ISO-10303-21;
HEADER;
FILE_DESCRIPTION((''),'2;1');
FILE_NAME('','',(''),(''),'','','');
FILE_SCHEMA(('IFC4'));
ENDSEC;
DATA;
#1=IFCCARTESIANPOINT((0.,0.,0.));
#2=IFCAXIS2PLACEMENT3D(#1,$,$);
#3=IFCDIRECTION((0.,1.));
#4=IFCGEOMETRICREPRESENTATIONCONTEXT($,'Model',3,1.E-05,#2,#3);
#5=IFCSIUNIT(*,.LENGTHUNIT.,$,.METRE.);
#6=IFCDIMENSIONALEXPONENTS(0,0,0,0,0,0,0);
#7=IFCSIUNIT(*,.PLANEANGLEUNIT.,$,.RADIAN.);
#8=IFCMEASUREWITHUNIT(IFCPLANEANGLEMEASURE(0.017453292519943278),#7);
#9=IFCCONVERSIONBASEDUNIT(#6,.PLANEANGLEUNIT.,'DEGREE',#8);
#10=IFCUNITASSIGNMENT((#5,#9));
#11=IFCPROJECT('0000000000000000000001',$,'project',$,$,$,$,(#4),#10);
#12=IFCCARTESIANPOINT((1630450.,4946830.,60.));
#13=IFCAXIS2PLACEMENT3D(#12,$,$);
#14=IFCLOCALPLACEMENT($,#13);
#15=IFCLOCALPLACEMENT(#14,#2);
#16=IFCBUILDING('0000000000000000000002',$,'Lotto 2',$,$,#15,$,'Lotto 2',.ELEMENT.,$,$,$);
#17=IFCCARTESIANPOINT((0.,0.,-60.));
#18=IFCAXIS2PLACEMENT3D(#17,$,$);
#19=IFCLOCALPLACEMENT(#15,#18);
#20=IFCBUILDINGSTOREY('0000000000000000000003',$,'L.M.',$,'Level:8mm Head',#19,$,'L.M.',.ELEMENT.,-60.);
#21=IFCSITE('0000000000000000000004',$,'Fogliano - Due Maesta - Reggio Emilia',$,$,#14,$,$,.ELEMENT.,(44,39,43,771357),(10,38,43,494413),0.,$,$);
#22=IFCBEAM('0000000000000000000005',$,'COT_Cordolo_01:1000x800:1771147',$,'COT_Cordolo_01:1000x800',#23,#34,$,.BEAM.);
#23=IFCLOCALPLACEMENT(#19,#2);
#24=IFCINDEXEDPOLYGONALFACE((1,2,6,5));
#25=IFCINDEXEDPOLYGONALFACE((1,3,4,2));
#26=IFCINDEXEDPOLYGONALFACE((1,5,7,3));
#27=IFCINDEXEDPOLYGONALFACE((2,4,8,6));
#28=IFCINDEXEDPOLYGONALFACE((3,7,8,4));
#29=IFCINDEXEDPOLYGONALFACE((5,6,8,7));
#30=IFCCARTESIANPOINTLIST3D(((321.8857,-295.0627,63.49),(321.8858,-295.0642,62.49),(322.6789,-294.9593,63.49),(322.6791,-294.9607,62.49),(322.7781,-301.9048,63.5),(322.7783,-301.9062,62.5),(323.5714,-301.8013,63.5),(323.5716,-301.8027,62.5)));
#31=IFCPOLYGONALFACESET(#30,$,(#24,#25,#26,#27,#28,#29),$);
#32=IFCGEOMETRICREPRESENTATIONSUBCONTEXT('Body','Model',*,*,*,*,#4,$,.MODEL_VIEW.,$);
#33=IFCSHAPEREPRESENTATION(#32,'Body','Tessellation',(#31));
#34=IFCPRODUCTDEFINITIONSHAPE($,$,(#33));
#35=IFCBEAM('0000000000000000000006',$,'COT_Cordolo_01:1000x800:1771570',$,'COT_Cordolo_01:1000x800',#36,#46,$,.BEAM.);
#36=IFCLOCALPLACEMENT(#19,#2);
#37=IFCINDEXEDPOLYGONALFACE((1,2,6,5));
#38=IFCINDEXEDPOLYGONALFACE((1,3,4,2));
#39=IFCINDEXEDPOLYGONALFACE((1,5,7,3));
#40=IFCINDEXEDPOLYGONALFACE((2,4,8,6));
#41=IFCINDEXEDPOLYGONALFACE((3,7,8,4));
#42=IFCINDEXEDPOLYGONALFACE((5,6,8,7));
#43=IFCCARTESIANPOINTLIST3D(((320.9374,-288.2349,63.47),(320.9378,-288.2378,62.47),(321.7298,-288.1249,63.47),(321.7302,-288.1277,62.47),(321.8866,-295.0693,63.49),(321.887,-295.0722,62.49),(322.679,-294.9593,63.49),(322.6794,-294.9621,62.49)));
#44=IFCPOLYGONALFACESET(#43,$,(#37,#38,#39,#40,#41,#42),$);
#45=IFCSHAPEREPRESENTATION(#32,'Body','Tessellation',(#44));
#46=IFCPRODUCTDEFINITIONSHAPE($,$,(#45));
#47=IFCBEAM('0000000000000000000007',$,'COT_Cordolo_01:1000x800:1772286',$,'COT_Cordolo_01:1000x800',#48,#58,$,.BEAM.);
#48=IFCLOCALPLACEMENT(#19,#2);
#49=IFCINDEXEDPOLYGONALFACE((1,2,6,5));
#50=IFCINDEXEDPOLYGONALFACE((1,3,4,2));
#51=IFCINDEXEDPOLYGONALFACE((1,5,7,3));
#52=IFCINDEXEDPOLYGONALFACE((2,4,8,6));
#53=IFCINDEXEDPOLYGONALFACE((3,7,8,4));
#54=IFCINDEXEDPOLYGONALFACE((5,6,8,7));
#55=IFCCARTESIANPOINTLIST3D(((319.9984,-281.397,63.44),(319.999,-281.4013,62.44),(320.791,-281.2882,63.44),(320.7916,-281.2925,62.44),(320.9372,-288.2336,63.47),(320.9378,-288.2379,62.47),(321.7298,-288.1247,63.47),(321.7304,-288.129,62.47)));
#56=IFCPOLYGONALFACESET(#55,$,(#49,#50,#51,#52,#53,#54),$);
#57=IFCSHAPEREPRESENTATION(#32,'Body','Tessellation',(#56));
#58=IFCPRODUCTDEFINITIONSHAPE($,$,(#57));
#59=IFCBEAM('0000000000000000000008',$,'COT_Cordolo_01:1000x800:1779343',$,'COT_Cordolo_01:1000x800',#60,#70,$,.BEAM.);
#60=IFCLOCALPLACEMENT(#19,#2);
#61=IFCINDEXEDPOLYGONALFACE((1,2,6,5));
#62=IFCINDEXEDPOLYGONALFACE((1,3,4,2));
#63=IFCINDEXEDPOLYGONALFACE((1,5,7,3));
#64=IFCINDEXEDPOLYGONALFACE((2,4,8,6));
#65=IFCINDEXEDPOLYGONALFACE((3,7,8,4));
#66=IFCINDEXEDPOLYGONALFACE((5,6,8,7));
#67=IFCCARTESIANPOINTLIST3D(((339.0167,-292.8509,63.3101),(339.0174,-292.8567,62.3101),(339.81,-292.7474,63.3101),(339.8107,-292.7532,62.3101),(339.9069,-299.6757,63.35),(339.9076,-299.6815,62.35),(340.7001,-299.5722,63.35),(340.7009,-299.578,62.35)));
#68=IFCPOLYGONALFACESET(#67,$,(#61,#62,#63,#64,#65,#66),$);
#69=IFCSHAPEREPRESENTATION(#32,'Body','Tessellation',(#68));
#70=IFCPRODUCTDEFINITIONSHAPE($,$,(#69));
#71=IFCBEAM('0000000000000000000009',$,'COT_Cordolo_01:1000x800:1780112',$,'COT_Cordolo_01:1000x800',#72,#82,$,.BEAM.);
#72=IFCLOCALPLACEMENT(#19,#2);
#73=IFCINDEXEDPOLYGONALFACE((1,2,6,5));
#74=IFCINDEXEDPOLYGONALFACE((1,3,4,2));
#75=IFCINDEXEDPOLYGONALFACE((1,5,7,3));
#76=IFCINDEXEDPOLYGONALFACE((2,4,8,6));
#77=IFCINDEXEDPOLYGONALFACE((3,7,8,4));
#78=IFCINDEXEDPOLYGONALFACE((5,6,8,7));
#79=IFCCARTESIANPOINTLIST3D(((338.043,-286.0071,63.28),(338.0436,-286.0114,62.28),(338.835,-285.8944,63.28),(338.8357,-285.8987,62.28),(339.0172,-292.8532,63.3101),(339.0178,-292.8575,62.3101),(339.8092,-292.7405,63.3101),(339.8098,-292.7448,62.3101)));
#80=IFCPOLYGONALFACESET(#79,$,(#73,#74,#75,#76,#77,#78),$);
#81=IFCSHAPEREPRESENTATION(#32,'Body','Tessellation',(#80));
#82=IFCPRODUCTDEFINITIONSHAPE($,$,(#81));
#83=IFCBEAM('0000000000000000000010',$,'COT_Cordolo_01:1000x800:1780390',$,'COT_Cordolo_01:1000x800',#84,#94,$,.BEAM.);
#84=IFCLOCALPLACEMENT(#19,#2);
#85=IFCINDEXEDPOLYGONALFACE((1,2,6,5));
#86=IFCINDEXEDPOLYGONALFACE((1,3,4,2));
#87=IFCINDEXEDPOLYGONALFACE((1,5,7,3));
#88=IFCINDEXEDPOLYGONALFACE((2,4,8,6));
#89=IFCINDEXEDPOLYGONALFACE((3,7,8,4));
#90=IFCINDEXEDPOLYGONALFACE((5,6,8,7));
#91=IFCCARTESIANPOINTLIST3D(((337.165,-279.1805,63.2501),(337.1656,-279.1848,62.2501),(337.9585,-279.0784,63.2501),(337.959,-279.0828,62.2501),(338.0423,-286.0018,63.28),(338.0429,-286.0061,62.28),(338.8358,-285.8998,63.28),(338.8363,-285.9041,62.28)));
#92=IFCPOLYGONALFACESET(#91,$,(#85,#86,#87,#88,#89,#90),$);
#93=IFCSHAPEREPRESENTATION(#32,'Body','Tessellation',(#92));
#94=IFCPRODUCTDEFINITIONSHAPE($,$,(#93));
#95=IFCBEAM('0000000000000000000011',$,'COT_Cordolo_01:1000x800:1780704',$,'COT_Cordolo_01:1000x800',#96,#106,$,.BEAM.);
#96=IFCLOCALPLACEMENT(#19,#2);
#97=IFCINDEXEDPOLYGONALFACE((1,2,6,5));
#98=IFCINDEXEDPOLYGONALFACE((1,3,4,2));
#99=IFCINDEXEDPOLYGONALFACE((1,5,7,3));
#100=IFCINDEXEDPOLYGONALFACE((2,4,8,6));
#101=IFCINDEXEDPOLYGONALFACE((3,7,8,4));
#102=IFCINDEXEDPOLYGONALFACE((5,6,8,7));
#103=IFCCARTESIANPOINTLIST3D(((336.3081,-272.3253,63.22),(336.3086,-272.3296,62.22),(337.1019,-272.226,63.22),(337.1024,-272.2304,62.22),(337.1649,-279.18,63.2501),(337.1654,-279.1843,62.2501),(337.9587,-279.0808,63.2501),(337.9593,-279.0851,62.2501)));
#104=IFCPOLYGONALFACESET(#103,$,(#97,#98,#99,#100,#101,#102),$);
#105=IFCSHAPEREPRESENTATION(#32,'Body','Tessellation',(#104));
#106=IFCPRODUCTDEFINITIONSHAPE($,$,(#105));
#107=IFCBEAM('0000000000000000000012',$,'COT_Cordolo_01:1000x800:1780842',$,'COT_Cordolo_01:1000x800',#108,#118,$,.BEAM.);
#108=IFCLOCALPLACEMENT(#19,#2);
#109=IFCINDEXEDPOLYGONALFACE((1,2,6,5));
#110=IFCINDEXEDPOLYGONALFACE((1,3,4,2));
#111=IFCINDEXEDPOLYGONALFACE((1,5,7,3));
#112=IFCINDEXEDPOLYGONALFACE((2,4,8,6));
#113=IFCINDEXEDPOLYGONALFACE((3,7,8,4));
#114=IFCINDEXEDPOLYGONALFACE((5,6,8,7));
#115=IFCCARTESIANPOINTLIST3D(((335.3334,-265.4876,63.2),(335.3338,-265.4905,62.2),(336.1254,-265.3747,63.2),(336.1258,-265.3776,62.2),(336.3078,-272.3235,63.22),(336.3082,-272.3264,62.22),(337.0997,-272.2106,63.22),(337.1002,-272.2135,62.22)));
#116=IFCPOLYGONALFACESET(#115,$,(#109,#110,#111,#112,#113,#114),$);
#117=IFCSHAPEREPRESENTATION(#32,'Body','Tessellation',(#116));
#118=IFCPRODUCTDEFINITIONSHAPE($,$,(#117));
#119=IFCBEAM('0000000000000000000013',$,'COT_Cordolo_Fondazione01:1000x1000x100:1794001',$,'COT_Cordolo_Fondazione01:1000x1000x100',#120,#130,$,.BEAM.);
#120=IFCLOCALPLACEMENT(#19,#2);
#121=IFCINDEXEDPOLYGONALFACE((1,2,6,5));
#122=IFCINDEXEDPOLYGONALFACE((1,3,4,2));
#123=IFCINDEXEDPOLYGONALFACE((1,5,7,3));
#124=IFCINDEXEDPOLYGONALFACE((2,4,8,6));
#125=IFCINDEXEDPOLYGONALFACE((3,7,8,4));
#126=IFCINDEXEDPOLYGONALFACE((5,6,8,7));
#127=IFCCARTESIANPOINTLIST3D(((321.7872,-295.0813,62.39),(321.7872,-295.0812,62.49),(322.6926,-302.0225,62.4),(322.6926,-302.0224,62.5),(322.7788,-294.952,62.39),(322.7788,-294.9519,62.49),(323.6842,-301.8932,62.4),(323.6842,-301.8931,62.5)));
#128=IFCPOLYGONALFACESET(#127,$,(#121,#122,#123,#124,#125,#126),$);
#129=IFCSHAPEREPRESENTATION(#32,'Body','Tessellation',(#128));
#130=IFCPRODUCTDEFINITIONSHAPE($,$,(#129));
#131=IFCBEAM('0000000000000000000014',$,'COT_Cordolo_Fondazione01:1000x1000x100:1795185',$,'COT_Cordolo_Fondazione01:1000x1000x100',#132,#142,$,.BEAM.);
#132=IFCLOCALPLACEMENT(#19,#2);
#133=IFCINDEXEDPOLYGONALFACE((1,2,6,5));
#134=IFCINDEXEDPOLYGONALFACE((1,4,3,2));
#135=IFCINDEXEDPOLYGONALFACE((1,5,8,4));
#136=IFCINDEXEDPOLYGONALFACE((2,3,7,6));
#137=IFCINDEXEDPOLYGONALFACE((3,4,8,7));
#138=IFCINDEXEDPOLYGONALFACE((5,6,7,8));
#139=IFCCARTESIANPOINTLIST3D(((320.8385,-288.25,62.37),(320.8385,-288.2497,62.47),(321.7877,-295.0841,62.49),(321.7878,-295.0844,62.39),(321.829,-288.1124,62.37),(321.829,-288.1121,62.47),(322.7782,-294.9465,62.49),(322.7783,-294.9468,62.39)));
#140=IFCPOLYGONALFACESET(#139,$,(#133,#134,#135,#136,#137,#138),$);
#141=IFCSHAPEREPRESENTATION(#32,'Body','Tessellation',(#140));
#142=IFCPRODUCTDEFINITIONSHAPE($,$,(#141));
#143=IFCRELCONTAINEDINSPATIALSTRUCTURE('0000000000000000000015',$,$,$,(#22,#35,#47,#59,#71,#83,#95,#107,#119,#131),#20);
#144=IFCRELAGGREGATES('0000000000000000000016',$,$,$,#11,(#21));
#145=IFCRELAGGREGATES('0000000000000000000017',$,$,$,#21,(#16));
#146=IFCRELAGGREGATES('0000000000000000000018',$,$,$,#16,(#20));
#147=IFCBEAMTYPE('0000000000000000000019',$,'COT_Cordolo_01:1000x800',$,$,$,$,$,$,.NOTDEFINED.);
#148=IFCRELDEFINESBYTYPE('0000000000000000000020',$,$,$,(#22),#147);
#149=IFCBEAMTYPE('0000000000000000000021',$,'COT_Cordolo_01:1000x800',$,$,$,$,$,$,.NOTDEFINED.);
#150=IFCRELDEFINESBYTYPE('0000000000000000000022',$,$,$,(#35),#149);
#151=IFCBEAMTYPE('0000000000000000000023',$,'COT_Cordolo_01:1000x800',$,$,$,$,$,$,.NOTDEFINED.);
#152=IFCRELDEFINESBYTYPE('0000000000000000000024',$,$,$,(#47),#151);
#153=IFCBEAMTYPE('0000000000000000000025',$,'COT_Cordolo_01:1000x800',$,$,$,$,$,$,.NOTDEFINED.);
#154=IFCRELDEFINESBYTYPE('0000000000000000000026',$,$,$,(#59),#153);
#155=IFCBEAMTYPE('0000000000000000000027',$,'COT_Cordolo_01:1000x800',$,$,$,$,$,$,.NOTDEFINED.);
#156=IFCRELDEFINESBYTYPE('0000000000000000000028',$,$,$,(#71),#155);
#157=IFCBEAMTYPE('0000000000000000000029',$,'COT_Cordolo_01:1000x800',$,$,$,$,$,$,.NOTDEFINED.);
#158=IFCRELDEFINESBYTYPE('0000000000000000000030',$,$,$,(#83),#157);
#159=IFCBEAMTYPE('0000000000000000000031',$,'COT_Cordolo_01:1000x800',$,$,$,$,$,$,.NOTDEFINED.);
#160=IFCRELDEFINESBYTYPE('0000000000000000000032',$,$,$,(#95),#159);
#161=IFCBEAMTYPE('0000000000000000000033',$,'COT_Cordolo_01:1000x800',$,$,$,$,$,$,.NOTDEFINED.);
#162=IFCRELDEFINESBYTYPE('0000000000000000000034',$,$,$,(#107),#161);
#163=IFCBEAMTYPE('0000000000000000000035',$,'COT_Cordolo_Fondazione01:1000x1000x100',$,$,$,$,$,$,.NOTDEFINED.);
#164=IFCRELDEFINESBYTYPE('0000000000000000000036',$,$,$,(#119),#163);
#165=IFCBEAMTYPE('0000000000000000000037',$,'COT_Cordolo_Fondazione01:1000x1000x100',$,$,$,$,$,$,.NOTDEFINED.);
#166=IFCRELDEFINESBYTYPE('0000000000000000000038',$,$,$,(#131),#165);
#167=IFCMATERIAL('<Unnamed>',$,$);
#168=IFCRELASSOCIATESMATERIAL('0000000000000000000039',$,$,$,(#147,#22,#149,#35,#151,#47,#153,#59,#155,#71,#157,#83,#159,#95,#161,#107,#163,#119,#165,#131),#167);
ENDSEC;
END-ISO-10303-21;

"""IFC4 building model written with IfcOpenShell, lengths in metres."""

from ifc_helpers import new_model, entity, si_unit, converted_unit, direction, frame, origin, place, context, subcontext, project, spatial, indexed_curve, outline, extrude, source, transform, mapped, material, type_object, type_shapes, element, save


model = new_model("IFC4")

# Units and contexts
model_context = context("Model", 3, precision=1e-05, world=origin(), true_north=direction((0.0, 1.0)))
body_context = subcontext(model_context, "Body", "Model", "MODEL_VIEW")
ifc_project = project(units=[si_unit("LENGTHUNIT", "METRE"), converted_unit("PLANEANGLEUNIT", "DEGREE", entity("IfcPlaneAngleMeasure", 0.017453292519943278), si_unit("PLANEANGLEUNIT", "RADIAN"), dimensions=[0, 0, 0, 0, 0, 0, 0])], contexts=[model_context])

# Site, building, storey
site_placement = place(None, frame((1630450.0, 4946830.0, 60.0)))
site = spatial("IfcSite", under=ifc_project, at=site_placement, Name="Fogliano - Due Maesta - Reggio Emilia", CompositionType="ELEMENT", RefLatitude=(44, 39, 43, 771357), RefLongitude=(10, 38, 43, 494413), RefElevation=0.0)
building_placement = place(site_placement, origin())
building = spatial("IfcBuilding", under=site, at=building_placement, Name="Lotto 2", LongName="Lotto 2", CompositionType="ELEMENT")
storey_placement = place(building_placement, frame((0.0, 0.0, -60.0)))
storey = spatial("IfcBuildingStorey", under=building, at=storey_placement, Name="L.M.", ObjectType="Level:8mm Head", LongName="L.M.", CompositionType="ELEMENT", Elevation=-60.0)

# Beams
ifc_material_1 = material(Name="<Unnamed>")
beam_type_1 = type_object("IfcBeamType", Name="COT_Cordolo_01:1000x800", PredefinedType="NOTDEFINED", material=ifc_material_1)
shared_shape_1 = source(origin(), body_context, "Body", "SweptSolid", [
    extrude(outline(indexed_curve([(-3.45, -0.4), (3.45, -0.4), (3.45, 0.4), (-3.45, 0.4), (-3.45, -0.4)], self_intersect=False)), frame((0.0, 0.0, -0.5), z_axis=(0.0, 0.0, 1.0), x_axis=(-1.0, 0.0, 0.0)), (0.0, 0.0, 1.0), 1.0),
])
type_shapes(beam_type_1, [shared_shape_1])
beam_1_placement = place(storey_placement, frame((322.7286, -298.4327, 62.995), z_axis=(-0.000187, 0.001437, 0.999999), x_axis=(-0.129339, 0.991599, -0.001449)))
element("IfcBeam", 1, at=beam_1_placement, inside=storey, type_object=beam_type_1, material=ifc_material_1, Name="COT_Cordolo_01:1000x800:1771147", ObjectType="COT_Cordolo_01:1000x800", PredefinedType="BEAM", context=body_context, shape_type="MappedRepresentation", body=[
    mapped(shared_shape_1, transform((0.0, 0.0, 0.0), scale=1.0)),
])
beam_type_2 = type_object("IfcBeamType", Name="COT_Cordolo_01:1000x800", PredefinedType="NOTDEFINED", material=ifc_material_1)
shared_shape_2 = source(origin(), body_context, "Body", "SweptSolid", [
    extrude(outline(indexed_curve([(-3.45, -0.4), (3.45, -0.4), (3.45, 0.4), (-3.45, 0.4), (-3.45, -0.4)], self_intersect=False)), frame((0.0, 0.0, -0.5), z_axis=(0.0, 0.0, 1.0), x_axis=(-1.0, 0.0, 0.0)), (0.0, 0.0, 1.0), 1.0),
])
type_shapes(beam_type_2, [shared_shape_2])
beam_2_placement = place(storey_placement, frame((321.8084, -291.5985, 62.98), z_axis=(-0.000399, 0.002871, 0.999996), x_axis=(-0.137568, 0.990488, -0.002899)))
element("IfcBeam", 2, at=beam_2_placement, inside=storey, type_object=beam_type_2, material=ifc_material_1, Name="COT_Cordolo_01:1000x800:1771570", ObjectType="COT_Cordolo_01:1000x800", PredefinedType="BEAM", context=body_context, shape_type="MappedRepresentation", body=[
    mapped(shared_shape_2, transform((0.0, 0.0, 0.0), scale=1.0)),
])
beam_type_3 = type_object("IfcBeamType", Name="COT_Cordolo_01:1000x800", PredefinedType="NOTDEFINED", material=ifc_material_1)
shared_shape_3 = source(origin(), body_context, "Body", "SweptSolid", [
    extrude(outline(indexed_curve([(-3.4504, -0.4), (3.4504, -0.4), (3.4504, 0.4), (-3.4504, 0.4), (-3.4504, -0.4)], self_intersect=False)), frame((0.0, 0.0, -0.5), z_axis=(0.0, 0.0, 1.0), x_axis=(-1.0, 0.0, 0.0)), (0.0, 0.0, 1.0), 1.0),
])
type_shapes(beam_type_3, [shared_shape_3])
beam_3_placement = place(storey_placement, frame((320.8644, -284.763, 62.955), z_axis=(-0.000591, 0.004306, 0.999991), x_axis=(-0.13604, 0.990694, -0.004347)))
element("IfcBeam", 3, at=beam_3_placement, inside=storey, type_object=beam_type_3, material=ifc_material_1, Name="COT_Cordolo_01:1000x800:1772286", ObjectType="COT_Cordolo_01:1000x800", PredefinedType="BEAM", context=body_context, shape_type="MappedRepresentation", body=[
    mapped(shared_shape_3, transform((0.0, 0.0, 0.0), scale=1.0)),
])
beam_type_4 = type_object("IfcBeamType", Name="COT_Cordolo_01:1000x800", PredefinedType="NOTDEFINED", material=ifc_material_1)
shared_shape_4 = source(origin(), body_context, "Body", "SweptSolid", [
    extrude(outline(indexed_curve([(-3.4414, -0.4), (3.4414, -0.4), (3.4414, 0.4), (-3.4414, 0.4), (-3.4414, -0.4)], self_intersect=False)), frame((-0.0087, 0.0, -0.5), z_axis=(0.0, 0.0, 1.0), x_axis=(-1.0, 0.0, 0.0)), (0.0, 0.0, 1.0), 1.0),
])
type_shapes(beam_type_4, [shared_shape_4])
beam_4_placement = place(storey_placement, frame((339.8577, -296.2058, 62.83), z_axis=(-0.00075, 0.005748, 0.999983), x_axis=(-0.129337, 0.991584, -0.005797)))
element("IfcBeam", 4, at=beam_4_placement, inside=storey, type_object=beam_type_4, material=ifc_material_1, Name="COT_Cordolo_01:1000x800:1779343", ObjectType="COT_Cordolo_01:1000x800", PredefinedType="BEAM", context=body_context, shape_type="MappedRepresentation", body=[
    mapped(shared_shape_4, transform((0.0, 0.0, 0.0), scale=1.0)),
])
beam_type_5 = type_object("IfcBeamType", Name="COT_Cordolo_01:1000x800", PredefinedType="NOTDEFINED", material=ifc_material_1)
shared_shape_5 = source(origin(), body_context, "Body", "SweptSolid", [
    extrude(outline(indexed_curve([(-3.4576, -0.4), (3.4576, -0.4), (3.4576, 0.4), (-3.4576, 0.4), (-3.4576, -0.4)], self_intersect=False)), frame((-0.0075, 0.0, -0.5), z_axis=(0.0, 0.0, 1.0), x_axis=(-1.0, 0.0, 0.0)), (0.0, 0.0, 1.0), 1.0),
])
type_shapes(beam_type_5, [shared_shape_5])
beam_5_placement = place(storey_placement, frame((338.9254, -289.3685, 62.795), z_axis=(-0.000612, 0.004304, 0.999991), x_axis=(-0.140874, 0.990018, -0.004348)))
element("IfcBeam", 5, at=beam_5_placement, inside=storey, type_object=beam_type_5, material=ifc_material_1, Name="COT_Cordolo_01:1000x800:1780112", ObjectType="COT_Cordolo_01:1000x800", PredefinedType="BEAM", context=body_context, shape_type="MappedRepresentation", body=[
    mapped(shared_shape_5, transform((0.0, 0.0, 0.0), scale=1.0)),
])
beam_type_6 = type_object("IfcBeamType", Name="COT_Cordolo_01:1000x800", PredefinedType="NOTDEFINED", material=ifc_material_1)
shared_shape_6 = source(origin(), body_context, "Body", "SweptSolid", [
    extrude(outline(indexed_curve([(-3.4388, -0.4), (3.4388, -0.4), (3.4388, 0.4), (-3.4388, 0.4), (-3.4388, -0.4)], self_intersect=False)), frame((-0.0078, 0.0, -0.5), z_axis=(0.0, 0.0, 1.0), x_axis=(-1.0, 0.0, 0.0)), (0.0, 0.0, 1.0), 1.0),
])
type_shapes(beam_type_6, [shared_shape_6])
beam_6_placement = place(storey_placement, frame((337.9997, -282.5346, 62.765), z_axis=(-0.000555, 0.004317, 0.999991), x_axis=(-0.127557, 0.991822, -0.004352)))
element("IfcBeam", 6, at=beam_6_placement, inside=storey, type_object=beam_type_6, material=ifc_material_1, Name="COT_Cordolo_01:1000x800:1780390", ObjectType="COT_Cordolo_01:1000x800", PredefinedType="BEAM", context=body_context, shape_type="MappedRepresentation", body=[
    mapped(shared_shape_6, transform((0.0, 0.0, 0.0), scale=1.0)),
])
beam_type_7 = type_object("IfcBeamType", Name="COT_Cordolo_01:1000x800", PredefinedType="NOTDEFINED", material=ifc_material_1)
shared_shape_7 = source(origin(), body_context, "Body", "SweptSolid", [
    extrude(outline(indexed_curve([(-3.4541, -0.4), (3.4541, -0.4), (3.4541, 0.4), (-3.4541, 0.4), (-3.4541, -0.4)], self_intersect=False)), frame((-0.0075, 0.0, -0.5), z_axis=(0.0, 0.0, 1.0), x_axis=(-1.0, 0.0, 0.0)), (0.0, 0.0, 1.0), 1.0),
])
type_shapes(beam_type_7, [shared_shape_7])
beam_7_placement = place(storey_placement, frame((337.1327, -275.6977, 62.735), z_axis=(-0.00054, 0.004319, 0.999991), x_axis=(-0.124034, 0.992268, -0.004352)))
element("IfcBeam", 7, at=beam_7_placement, inside=storey, type_object=beam_type_7, material=ifc_material_1, Name="COT_Cordolo_01:1000x800:1780704", ObjectType="COT_Cordolo_01:1000x800", PredefinedType="BEAM", context=body_context, shape_type="MappedRepresentation", body=[
    mapped(shared_shape_7, transform((0.0, 0.0, 0.0), scale=1.0)),
])
beam_type_8 = type_object("IfcBeamType", Name="COT_Cordolo_01:1000x800", PredefinedType="NOTDEFINED", material=ifc_material_1)
shared_shape_8 = source(origin(), body_context, "Body", "SweptSolid", [
    extrude(outline(indexed_curve([(-3.4525, -0.4), (3.4525, -0.4), (3.4525, 0.4), (-3.4525, 0.4), (-3.4525, -0.4)], self_intersect=False)), frame((-0.0076, 0.0, -0.5), z_axis=(0.0, 0.0, 1.0), x_axis=(-1.0, 0.0, 0.0)), (0.0, 0.0, 1.0), 1.0),
])
type_shapes(beam_type_8, [shared_shape_8])
beam_8_placement = place(storey_placement, frame((336.2157, -268.8431, 62.71), z_axis=(-0.000407, 0.002858, 0.999996), x_axis=(-0.141112, 0.989989, -0.002886)))
element("IfcBeam", 8, at=beam_8_placement, inside=storey, type_object=beam_type_8, material=ifc_material_1, Name="COT_Cordolo_01:1000x800:1780842", ObjectType="COT_Cordolo_01:1000x800", PredefinedType="BEAM", context=body_context, shape_type="MappedRepresentation", body=[
    mapped(shared_shape_8, transform((0.0, 0.0, 0.0), scale=1.0)),
])
beam_type_9 = type_object("IfcBeamType", Name="COT_Cordolo_Fondazione01:1000x1000x100", PredefinedType="NOTDEFINED", material=ifc_material_1)
shared_shape_9 = source(origin(), body_context, "Body", "SweptSolid", [
    extrude(outline(indexed_curve([(-3.5, -0.5), (3.5, -0.5), (3.5, 0.5), (-3.5, 0.5), (-3.5, -0.5)], self_intersect=False)), frame((0.0, 0.0, -0.05), z_axis=(0.0, 0.0, 1.0), x_axis=(-1.0, 0.0, 0.0)), (0.0, 0.0, 1.0), 0.1),
])
type_shapes(beam_type_9, [shared_shape_9])
beam_9_placement = place(storey_placement, frame((322.7357, -298.4872, 62.445), z_axis=(-0.000185, 0.001417, 0.999999), x_axis=(-0.129339, 0.991599, -0.001429)))
element("IfcBeam", 9, at=beam_9_placement, inside=storey, type_object=beam_type_9, material=ifc_material_1, Name="COT_Cordolo_Fondazione01:1000x1000x100:1794001", ObjectType="COT_Cordolo_Fondazione01:1000x1000x100", PredefinedType="BEAM", context=body_context, shape_type="MappedRepresentation", body=[
    mapped(shared_shape_9, transform((0.0, 0.0, 0.0), scale=1.0)),
])
beam_type_10 = type_object("IfcBeamType", Name="COT_Cordolo_Fondazione01:1000x1000x100", PredefinedType="NOTDEFINED", material=ifc_material_1)
shared_shape_10 = source(origin(), body_context, "Body", "SweptSolid", [
    extrude(outline(indexed_curve([(-3.45, -0.5), (3.45, -0.5), (3.45, 0.5), (-3.45, 0.5), (-3.45, -0.5)], self_intersect=False)), frame((0.0, 0.0, -0.05), z_axis=(0.0, 0.0, 1.0), x_axis=(-1.0, 0.0, 0.0)), (0.0, 0.0, 1.0), 0.1),
])
type_shapes(beam_type_10, [shared_shape_10])
beam_10_placement = place(storey_placement, frame((321.8084, -291.5982, 62.43), z_axis=(-0.000399, 0.002871, 0.999996), x_axis=(-0.137568, 0.990488, -0.002899)))
element("IfcBeam", 10, at=beam_10_placement, inside=storey, type_object=beam_type_10, material=ifc_material_1, Name="COT_Cordolo_Fondazione01:1000x1000x100:1795185", ObjectType="COT_Cordolo_Fondazione01:1000x1000x100", PredefinedType="BEAM", context=body_context, shape_type="MappedRepresentation", body=[
    mapped(shared_shape_10, transform((0.0, 0.0, 0.0), scale=1.0)),
])

save(model, "model.ifc")
